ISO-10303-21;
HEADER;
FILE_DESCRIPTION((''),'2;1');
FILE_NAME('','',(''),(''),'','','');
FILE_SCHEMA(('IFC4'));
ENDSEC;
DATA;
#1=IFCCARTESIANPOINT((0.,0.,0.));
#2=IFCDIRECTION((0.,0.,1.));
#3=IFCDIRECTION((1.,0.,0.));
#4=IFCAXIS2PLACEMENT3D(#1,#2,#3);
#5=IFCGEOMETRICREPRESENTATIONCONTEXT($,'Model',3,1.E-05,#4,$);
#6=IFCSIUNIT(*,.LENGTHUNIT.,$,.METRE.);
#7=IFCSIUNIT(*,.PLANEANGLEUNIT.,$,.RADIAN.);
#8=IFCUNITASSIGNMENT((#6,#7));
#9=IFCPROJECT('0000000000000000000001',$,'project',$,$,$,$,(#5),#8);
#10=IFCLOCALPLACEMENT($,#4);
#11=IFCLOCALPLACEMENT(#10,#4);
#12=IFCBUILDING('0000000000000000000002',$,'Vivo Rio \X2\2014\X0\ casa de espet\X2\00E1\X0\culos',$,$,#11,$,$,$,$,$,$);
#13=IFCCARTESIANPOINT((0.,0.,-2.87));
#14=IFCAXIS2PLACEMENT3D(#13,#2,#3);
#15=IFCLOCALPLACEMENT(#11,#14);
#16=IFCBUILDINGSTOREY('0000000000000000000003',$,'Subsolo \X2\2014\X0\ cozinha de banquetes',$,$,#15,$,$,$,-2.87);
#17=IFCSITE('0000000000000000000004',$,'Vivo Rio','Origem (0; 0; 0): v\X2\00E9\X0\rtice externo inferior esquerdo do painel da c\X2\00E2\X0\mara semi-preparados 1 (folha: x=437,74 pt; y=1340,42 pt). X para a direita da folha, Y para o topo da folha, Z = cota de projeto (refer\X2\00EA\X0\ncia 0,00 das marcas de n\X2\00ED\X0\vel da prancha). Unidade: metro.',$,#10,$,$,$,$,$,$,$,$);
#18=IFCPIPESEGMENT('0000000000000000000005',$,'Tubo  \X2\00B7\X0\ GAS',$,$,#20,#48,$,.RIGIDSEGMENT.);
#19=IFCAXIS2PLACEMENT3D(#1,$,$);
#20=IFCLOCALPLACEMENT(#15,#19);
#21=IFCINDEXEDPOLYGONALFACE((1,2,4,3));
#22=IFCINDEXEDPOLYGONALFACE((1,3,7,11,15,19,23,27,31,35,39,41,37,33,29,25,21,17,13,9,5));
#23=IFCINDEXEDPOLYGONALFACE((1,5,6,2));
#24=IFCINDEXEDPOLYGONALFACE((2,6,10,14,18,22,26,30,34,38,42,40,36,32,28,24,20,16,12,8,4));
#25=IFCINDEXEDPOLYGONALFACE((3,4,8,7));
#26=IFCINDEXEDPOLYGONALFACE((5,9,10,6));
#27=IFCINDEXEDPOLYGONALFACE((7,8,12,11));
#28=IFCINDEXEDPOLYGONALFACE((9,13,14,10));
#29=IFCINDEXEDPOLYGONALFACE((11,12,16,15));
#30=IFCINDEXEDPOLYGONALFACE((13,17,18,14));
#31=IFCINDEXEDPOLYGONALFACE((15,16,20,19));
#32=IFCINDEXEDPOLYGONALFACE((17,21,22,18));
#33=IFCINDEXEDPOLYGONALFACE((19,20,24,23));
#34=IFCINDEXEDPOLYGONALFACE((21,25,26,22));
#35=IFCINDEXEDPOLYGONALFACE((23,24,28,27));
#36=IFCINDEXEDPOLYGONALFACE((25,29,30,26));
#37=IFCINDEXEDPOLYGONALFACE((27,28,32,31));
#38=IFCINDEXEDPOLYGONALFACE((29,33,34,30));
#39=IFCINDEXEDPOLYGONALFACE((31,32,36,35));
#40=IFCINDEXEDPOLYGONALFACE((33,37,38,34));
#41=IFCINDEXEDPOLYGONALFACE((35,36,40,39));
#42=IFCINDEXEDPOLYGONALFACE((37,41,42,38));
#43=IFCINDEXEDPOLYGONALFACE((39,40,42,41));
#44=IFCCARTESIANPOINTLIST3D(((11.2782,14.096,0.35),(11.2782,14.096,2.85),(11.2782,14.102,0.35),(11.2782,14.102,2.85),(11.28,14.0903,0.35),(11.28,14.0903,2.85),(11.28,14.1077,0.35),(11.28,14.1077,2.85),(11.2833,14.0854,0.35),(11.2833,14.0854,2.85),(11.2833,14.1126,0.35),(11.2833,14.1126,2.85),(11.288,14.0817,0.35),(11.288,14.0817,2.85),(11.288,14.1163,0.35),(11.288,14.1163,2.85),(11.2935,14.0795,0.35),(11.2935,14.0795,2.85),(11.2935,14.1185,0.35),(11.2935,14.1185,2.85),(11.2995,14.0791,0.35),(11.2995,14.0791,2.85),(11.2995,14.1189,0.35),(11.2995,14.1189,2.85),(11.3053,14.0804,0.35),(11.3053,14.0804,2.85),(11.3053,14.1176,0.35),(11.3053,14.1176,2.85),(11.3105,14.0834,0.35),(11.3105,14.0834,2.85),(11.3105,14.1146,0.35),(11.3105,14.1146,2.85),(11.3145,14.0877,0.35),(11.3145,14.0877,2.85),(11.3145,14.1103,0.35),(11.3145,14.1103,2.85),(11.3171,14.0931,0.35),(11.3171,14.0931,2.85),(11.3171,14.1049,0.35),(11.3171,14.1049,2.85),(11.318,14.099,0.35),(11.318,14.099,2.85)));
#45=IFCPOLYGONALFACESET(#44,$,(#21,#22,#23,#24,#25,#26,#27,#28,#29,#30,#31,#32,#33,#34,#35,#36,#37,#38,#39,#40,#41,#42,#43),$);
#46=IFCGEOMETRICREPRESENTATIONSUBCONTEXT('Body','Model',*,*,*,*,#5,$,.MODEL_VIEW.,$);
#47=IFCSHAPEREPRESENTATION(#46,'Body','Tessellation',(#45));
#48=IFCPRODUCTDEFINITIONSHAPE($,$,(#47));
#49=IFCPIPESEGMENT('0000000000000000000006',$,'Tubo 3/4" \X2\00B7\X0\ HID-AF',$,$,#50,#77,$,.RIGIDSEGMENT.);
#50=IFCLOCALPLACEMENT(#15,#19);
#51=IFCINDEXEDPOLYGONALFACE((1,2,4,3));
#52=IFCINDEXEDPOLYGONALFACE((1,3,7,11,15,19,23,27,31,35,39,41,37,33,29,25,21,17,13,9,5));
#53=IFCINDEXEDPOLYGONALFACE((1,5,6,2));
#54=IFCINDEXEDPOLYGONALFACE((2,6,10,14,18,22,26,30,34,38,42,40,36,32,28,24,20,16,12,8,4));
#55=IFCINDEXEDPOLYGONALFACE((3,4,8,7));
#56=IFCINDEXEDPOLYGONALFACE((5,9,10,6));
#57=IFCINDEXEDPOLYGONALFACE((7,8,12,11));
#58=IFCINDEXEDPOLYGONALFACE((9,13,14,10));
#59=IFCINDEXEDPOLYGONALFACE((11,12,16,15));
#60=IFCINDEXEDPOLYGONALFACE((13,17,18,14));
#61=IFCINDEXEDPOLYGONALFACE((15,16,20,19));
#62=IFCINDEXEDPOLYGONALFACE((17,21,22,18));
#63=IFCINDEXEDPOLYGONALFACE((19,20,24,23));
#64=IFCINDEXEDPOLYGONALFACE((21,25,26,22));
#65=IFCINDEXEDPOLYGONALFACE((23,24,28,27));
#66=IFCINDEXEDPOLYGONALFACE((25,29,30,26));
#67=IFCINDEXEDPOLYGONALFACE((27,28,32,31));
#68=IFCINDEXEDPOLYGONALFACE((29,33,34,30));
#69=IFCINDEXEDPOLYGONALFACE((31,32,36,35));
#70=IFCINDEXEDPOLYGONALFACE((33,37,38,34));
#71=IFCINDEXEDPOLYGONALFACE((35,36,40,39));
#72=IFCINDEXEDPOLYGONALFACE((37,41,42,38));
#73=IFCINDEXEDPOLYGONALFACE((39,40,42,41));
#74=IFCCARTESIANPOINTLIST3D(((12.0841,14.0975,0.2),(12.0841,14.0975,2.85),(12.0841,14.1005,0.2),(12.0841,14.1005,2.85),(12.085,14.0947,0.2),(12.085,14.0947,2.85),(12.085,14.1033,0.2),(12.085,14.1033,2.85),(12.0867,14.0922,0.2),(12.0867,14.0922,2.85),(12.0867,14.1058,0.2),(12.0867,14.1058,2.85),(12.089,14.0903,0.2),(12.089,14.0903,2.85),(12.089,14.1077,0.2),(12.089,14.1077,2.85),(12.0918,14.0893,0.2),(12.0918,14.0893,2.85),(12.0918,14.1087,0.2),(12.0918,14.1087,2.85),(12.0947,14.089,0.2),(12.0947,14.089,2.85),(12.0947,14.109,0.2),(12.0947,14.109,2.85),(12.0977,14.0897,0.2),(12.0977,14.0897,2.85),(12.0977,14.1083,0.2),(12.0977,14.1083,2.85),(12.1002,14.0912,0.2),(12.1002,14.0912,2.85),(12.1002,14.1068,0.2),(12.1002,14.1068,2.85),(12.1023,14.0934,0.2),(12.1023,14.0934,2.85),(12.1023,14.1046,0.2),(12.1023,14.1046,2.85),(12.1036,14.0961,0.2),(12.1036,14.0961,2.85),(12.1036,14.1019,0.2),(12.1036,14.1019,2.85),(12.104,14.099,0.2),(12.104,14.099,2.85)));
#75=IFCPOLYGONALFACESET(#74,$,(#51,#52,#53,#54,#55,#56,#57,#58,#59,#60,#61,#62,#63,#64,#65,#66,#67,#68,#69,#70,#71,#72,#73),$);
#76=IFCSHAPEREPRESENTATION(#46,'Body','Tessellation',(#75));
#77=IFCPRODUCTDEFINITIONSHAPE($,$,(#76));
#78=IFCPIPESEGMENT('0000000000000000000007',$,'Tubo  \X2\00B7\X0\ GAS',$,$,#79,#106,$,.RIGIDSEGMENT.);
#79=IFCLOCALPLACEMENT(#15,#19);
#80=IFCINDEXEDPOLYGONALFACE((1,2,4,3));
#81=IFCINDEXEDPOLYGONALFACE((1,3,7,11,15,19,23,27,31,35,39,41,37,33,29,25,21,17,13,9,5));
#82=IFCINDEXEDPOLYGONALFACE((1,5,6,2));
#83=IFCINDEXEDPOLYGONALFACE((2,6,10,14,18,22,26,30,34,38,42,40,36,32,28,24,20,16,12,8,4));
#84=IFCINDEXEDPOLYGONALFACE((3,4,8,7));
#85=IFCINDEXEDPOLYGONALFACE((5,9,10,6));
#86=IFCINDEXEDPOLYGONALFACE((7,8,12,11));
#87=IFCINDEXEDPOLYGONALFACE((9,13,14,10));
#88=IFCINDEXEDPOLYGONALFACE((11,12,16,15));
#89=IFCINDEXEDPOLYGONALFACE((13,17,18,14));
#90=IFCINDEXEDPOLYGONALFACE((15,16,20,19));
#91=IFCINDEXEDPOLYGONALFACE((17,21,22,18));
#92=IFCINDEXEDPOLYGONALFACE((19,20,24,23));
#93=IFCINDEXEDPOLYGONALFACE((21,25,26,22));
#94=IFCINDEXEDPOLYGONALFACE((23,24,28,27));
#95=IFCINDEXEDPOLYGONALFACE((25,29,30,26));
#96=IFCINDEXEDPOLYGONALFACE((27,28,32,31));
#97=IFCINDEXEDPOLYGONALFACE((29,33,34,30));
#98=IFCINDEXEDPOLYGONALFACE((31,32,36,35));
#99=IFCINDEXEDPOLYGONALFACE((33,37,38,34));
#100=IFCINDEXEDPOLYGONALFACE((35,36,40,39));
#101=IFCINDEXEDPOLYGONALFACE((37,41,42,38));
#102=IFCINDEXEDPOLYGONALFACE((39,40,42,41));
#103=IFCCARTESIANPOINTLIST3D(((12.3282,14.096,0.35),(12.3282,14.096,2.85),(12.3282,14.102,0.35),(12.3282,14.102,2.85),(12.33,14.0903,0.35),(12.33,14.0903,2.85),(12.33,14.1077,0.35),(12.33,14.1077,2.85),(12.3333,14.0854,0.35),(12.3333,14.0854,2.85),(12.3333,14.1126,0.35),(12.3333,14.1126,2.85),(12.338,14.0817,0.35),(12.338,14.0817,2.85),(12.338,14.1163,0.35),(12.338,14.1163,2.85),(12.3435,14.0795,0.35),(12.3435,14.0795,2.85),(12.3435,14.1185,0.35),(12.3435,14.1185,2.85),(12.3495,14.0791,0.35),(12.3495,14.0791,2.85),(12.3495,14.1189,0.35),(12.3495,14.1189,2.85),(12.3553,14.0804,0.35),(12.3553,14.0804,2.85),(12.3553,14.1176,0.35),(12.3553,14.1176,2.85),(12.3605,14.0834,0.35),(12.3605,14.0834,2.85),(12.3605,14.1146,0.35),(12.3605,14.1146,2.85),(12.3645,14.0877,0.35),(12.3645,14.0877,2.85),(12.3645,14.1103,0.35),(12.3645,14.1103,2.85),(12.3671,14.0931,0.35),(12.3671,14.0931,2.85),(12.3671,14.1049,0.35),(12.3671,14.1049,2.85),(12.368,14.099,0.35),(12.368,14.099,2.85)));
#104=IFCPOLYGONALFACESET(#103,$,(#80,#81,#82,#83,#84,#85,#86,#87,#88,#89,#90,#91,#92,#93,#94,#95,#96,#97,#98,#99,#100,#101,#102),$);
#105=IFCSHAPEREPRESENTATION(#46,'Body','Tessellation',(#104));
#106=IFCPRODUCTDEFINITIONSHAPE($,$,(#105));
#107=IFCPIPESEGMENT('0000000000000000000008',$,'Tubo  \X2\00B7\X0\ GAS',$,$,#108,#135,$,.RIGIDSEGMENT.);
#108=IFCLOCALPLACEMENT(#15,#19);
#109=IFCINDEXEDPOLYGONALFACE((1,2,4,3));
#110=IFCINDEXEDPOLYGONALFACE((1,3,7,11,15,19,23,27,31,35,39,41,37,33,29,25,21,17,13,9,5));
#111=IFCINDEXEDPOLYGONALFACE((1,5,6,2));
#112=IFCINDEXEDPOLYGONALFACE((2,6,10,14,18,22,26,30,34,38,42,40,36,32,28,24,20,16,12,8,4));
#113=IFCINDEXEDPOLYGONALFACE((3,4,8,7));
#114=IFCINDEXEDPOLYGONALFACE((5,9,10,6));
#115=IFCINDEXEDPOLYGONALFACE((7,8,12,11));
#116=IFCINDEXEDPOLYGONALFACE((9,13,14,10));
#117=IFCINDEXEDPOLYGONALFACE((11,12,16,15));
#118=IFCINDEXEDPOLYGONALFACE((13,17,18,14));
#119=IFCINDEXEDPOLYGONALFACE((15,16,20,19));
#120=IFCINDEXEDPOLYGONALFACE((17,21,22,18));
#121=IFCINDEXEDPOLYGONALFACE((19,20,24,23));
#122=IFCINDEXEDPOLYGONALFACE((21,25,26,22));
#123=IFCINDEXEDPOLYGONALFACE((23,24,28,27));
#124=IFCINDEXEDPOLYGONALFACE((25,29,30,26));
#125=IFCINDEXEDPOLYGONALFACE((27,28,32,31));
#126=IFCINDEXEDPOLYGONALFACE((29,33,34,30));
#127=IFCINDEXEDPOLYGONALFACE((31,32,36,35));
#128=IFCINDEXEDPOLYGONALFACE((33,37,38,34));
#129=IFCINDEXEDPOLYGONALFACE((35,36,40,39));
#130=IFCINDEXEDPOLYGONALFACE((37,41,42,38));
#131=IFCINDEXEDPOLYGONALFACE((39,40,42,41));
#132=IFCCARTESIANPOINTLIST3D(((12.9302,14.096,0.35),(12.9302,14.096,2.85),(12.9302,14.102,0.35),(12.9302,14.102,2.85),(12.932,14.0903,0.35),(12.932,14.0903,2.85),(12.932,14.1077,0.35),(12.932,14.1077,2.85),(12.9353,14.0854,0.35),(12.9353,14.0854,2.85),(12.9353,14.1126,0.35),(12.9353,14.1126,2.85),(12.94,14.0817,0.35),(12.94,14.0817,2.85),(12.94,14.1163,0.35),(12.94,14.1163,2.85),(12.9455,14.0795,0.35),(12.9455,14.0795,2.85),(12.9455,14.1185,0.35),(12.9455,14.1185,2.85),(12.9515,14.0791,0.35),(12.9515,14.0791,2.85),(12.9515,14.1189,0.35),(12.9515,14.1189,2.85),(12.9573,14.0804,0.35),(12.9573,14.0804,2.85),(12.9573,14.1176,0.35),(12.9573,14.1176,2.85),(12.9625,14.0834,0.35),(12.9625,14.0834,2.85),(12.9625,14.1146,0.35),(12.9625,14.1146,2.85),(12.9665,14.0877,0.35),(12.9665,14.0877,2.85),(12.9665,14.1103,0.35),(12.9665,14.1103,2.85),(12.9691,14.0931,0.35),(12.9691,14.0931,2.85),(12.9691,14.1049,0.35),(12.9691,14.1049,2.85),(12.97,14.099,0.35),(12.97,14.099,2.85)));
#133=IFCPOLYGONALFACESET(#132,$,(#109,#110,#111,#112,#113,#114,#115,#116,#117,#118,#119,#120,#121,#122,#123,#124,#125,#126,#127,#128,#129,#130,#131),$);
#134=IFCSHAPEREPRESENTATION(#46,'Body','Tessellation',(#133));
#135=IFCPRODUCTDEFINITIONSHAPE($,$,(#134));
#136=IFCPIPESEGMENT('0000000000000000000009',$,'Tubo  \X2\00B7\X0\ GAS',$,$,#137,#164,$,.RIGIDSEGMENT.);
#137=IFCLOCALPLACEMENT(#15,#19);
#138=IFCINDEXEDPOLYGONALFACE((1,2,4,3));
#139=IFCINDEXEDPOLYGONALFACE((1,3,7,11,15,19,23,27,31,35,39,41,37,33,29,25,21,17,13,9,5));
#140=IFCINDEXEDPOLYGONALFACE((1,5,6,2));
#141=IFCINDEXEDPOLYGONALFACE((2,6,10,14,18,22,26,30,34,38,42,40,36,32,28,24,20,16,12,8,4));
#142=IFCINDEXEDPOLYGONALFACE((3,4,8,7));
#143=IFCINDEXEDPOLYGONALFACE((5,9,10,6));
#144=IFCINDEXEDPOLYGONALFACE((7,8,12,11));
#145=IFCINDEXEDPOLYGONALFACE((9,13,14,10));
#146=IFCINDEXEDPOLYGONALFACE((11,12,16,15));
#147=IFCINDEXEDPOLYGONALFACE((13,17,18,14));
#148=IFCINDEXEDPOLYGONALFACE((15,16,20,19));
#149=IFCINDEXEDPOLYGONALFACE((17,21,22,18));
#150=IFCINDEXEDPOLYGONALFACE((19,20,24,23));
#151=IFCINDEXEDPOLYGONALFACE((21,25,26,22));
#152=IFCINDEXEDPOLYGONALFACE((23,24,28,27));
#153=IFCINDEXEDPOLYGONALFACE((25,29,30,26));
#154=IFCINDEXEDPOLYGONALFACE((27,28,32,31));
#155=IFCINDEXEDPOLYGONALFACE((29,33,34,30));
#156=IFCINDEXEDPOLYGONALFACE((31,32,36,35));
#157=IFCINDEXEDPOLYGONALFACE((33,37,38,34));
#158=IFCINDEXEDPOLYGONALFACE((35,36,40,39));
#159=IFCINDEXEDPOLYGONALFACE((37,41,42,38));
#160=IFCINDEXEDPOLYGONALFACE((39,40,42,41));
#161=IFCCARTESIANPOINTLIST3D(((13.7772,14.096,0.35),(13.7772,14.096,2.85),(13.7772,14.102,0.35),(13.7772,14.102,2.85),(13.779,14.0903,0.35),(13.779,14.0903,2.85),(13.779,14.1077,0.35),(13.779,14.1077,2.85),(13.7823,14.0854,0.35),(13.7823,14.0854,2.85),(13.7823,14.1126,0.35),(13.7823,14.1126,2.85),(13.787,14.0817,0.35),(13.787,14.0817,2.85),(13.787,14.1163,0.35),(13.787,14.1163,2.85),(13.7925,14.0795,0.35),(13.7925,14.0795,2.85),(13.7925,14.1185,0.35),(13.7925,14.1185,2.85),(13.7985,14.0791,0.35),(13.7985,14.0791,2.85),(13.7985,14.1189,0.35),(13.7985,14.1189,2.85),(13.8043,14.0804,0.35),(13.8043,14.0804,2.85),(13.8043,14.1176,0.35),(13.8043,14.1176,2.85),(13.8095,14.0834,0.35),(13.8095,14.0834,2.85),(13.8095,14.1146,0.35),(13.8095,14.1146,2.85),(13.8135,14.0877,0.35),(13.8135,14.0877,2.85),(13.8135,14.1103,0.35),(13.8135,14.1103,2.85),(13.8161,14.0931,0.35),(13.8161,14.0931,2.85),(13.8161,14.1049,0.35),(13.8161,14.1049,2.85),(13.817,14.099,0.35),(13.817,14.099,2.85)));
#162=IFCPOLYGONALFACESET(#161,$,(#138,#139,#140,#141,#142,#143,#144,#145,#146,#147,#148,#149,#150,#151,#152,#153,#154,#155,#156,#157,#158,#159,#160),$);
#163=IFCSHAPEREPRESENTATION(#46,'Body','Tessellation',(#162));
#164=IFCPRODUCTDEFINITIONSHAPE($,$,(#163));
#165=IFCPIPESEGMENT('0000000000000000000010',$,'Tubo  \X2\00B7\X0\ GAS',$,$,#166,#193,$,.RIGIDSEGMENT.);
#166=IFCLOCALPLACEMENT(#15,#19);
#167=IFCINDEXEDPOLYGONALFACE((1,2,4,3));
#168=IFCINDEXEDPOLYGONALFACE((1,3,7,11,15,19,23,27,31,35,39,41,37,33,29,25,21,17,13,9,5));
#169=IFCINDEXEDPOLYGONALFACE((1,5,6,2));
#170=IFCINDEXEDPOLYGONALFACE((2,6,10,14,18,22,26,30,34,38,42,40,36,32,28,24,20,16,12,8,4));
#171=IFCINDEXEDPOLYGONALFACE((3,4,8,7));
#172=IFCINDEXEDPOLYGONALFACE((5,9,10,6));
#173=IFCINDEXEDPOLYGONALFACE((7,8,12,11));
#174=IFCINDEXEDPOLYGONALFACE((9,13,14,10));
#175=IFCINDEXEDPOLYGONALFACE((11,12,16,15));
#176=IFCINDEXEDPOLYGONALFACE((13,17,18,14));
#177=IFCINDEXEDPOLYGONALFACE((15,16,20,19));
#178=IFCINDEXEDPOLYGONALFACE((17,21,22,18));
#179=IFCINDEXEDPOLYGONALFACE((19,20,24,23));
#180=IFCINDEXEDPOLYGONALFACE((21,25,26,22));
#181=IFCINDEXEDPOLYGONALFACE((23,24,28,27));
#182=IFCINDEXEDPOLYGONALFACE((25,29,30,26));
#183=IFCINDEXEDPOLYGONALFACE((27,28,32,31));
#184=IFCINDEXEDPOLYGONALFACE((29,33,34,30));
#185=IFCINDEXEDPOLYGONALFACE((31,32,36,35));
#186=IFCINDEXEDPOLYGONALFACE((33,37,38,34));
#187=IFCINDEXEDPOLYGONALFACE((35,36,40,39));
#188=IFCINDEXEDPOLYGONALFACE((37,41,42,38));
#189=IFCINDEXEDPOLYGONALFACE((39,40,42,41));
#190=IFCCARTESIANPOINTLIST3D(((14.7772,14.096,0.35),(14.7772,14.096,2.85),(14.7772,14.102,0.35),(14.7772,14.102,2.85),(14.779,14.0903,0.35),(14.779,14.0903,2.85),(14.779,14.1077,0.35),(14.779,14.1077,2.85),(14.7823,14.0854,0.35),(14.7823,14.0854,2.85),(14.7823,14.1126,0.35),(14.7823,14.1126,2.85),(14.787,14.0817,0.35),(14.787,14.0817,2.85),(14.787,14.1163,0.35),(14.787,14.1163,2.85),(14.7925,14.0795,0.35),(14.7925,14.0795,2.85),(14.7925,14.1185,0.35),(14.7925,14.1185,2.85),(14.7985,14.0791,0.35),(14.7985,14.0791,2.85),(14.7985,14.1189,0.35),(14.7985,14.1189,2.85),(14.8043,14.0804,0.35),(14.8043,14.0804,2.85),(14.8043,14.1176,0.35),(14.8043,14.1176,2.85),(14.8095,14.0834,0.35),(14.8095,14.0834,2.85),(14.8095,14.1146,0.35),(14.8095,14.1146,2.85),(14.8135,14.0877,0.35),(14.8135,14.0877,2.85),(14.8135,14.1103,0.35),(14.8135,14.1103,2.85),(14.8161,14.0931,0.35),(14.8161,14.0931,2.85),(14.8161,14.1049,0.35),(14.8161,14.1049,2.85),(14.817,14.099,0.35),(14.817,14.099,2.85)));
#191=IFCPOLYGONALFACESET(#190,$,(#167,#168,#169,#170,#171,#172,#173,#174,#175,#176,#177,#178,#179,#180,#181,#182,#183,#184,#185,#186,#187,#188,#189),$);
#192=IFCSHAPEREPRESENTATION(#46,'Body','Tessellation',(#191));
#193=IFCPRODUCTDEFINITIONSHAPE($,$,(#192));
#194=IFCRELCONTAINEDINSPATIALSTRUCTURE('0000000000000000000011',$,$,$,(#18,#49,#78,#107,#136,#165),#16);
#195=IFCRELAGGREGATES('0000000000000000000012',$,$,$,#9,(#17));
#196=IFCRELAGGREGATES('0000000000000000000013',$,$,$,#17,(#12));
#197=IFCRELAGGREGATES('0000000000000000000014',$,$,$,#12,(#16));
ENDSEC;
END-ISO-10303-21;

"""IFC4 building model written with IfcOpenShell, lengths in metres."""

from ifc_helpers import new_model, si_unit, frame, origin_with_axes, origin_2d, place, context, subcontext, project, spatial, circle, extrude, element, save


model = new_model("IFC4")

# Units and contexts
model_context = context("Model", 3, precision=1e-05, world=origin_with_axes())
body_context = subcontext(model_context, "Body", "Model", "MODEL_VIEW")
ifc_project = project(units=[si_unit("LENGTHUNIT", "METRE"), si_unit("PLANEANGLEUNIT", "RADIAN")], contexts=[model_context])

# Site, building, storey
site_placement = place(None, origin_with_axes())
site = spatial("IfcSite", under=ifc_project, at=site_placement, Name="Vivo Rio", Description="Origem (0; 0; 0): vértice externo inferior esquerdo do painel da câmara semi-preparados 1 (folha: x=437,74 pt; y=1340,42 pt). X para a direita da folha, Y para o topo da folha, Z = cota de projeto (referência 0,00 das marcas de nível da prancha). Unidade: metro.")
building_placement = place(site_placement, origin_with_axes())
building = spatial("IfcBuilding", under=site, at=building_placement, Name="Vivo Rio — casa de espetáculos")
storey_placement = place(building_placement, frame((0.0, 0.0, -2.87), z_axis=(0.0, 0.0, 1.0), x_axis=(1.0, 0.0, 0.0)))
storey = spatial("IfcBuildingStorey", under=building, at=storey_placement, Name="Subsolo — cozinha de banquetes", Elevation=-2.87)

# Pipe segments
pipe_segment_1_placement = place(storey_placement, origin_with_axes())
element("IfcPipeSegment", 1, at=pipe_segment_1_placement, inside=storey, Name="Tubo  · GAS", PredefinedType="RIGIDSEGMENT", context=body_context, shape_type="SweptSolid", body=[
    extrude(circle(Radius=0.02, at=origin_2d()), frame((11.298, 14.099, 2.85), z_axis=(0.0, 0.0, -1.0), x_axis=(1.0, 0.0, 0.0)), (0.0, 0.0, 1.0), 2.5),
])
pipe_segment_2_placement = place(storey_placement, origin_with_axes())
element("IfcPipeSegment", 2, at=pipe_segment_2_placement, inside=storey, Name="Tubo 3/4\" · HID-AF", PredefinedType="RIGIDSEGMENT", context=body_context, shape_type="SweptSolid", body=[
    extrude(circle(Radius=0.01, at=origin_2d()), frame((12.094, 14.099, 2.85), z_axis=(0.0, 0.0, -1.0), x_axis=(1.0, 0.0, 0.0)), (0.0, 0.0, 1.0), 2.65),
])
pipe_segment_3_placement = place(storey_placement, origin_with_axes())
element("IfcPipeSegment", 3, at=pipe_segment_3_placement, inside=storey, Name="Tubo  · GAS", PredefinedType="RIGIDSEGMENT", context=body_context, shape_type="SweptSolid", body=[
    extrude(circle(Radius=0.02, at=origin_2d()), frame((12.348, 14.099, 2.85), z_axis=(0.0, 0.0, -1.0), x_axis=(1.0, 0.0, 0.0)), (0.0, 0.0, 1.0), 2.5),
])
pipe_segment_4_placement = place(storey_placement, origin_with_axes())
element("IfcPipeSegment", 4, at=pipe_segment_4_placement, inside=storey, Name="Tubo  · GAS", PredefinedType="RIGIDSEGMENT", context=body_context, shape_type="SweptSolid", body=[
    extrude(circle(Radius=0.02, at=origin_2d()), frame((12.95, 14.099, 2.85), z_axis=(0.0, 0.0, -1.0), x_axis=(1.0, 0.0, 0.0)), (0.0, 0.0, 1.0), 2.5),
])
pipe_segment_5_placement = place(storey_placement, origin_with_axes())
element("IfcPipeSegment", 5, at=pipe_segment_5_placement, inside=storey, Name="Tubo  · GAS", PredefinedType="RIGIDSEGMENT", context=body_context, shape_type="SweptSolid", body=[
    extrude(circle(Radius=0.02, at=origin_2d()), frame((13.797, 14.099, 2.85), z_axis=(0.0, 0.0, -1.0), x_axis=(1.0, 0.0, 0.0)), (0.0, 0.0, 1.0), 2.5),
])
pipe_segment_6_placement = place(storey_placement, origin_with_axes())
element("IfcPipeSegment", 6, at=pipe_segment_6_placement, inside=storey, Name="Tubo  · GAS", PredefinedType="RIGIDSEGMENT", context=body_context, shape_type="SweptSolid", body=[
    extrude(circle(Radius=0.02, at=origin_2d()), frame((14.797, 14.099, 2.85), z_axis=(0.0, 0.0, -1.0), x_axis=(1.0, 0.0, 0.0)), (0.0, 0.0, 1.0), 2.5),
])

save(model, "model.ifc")
